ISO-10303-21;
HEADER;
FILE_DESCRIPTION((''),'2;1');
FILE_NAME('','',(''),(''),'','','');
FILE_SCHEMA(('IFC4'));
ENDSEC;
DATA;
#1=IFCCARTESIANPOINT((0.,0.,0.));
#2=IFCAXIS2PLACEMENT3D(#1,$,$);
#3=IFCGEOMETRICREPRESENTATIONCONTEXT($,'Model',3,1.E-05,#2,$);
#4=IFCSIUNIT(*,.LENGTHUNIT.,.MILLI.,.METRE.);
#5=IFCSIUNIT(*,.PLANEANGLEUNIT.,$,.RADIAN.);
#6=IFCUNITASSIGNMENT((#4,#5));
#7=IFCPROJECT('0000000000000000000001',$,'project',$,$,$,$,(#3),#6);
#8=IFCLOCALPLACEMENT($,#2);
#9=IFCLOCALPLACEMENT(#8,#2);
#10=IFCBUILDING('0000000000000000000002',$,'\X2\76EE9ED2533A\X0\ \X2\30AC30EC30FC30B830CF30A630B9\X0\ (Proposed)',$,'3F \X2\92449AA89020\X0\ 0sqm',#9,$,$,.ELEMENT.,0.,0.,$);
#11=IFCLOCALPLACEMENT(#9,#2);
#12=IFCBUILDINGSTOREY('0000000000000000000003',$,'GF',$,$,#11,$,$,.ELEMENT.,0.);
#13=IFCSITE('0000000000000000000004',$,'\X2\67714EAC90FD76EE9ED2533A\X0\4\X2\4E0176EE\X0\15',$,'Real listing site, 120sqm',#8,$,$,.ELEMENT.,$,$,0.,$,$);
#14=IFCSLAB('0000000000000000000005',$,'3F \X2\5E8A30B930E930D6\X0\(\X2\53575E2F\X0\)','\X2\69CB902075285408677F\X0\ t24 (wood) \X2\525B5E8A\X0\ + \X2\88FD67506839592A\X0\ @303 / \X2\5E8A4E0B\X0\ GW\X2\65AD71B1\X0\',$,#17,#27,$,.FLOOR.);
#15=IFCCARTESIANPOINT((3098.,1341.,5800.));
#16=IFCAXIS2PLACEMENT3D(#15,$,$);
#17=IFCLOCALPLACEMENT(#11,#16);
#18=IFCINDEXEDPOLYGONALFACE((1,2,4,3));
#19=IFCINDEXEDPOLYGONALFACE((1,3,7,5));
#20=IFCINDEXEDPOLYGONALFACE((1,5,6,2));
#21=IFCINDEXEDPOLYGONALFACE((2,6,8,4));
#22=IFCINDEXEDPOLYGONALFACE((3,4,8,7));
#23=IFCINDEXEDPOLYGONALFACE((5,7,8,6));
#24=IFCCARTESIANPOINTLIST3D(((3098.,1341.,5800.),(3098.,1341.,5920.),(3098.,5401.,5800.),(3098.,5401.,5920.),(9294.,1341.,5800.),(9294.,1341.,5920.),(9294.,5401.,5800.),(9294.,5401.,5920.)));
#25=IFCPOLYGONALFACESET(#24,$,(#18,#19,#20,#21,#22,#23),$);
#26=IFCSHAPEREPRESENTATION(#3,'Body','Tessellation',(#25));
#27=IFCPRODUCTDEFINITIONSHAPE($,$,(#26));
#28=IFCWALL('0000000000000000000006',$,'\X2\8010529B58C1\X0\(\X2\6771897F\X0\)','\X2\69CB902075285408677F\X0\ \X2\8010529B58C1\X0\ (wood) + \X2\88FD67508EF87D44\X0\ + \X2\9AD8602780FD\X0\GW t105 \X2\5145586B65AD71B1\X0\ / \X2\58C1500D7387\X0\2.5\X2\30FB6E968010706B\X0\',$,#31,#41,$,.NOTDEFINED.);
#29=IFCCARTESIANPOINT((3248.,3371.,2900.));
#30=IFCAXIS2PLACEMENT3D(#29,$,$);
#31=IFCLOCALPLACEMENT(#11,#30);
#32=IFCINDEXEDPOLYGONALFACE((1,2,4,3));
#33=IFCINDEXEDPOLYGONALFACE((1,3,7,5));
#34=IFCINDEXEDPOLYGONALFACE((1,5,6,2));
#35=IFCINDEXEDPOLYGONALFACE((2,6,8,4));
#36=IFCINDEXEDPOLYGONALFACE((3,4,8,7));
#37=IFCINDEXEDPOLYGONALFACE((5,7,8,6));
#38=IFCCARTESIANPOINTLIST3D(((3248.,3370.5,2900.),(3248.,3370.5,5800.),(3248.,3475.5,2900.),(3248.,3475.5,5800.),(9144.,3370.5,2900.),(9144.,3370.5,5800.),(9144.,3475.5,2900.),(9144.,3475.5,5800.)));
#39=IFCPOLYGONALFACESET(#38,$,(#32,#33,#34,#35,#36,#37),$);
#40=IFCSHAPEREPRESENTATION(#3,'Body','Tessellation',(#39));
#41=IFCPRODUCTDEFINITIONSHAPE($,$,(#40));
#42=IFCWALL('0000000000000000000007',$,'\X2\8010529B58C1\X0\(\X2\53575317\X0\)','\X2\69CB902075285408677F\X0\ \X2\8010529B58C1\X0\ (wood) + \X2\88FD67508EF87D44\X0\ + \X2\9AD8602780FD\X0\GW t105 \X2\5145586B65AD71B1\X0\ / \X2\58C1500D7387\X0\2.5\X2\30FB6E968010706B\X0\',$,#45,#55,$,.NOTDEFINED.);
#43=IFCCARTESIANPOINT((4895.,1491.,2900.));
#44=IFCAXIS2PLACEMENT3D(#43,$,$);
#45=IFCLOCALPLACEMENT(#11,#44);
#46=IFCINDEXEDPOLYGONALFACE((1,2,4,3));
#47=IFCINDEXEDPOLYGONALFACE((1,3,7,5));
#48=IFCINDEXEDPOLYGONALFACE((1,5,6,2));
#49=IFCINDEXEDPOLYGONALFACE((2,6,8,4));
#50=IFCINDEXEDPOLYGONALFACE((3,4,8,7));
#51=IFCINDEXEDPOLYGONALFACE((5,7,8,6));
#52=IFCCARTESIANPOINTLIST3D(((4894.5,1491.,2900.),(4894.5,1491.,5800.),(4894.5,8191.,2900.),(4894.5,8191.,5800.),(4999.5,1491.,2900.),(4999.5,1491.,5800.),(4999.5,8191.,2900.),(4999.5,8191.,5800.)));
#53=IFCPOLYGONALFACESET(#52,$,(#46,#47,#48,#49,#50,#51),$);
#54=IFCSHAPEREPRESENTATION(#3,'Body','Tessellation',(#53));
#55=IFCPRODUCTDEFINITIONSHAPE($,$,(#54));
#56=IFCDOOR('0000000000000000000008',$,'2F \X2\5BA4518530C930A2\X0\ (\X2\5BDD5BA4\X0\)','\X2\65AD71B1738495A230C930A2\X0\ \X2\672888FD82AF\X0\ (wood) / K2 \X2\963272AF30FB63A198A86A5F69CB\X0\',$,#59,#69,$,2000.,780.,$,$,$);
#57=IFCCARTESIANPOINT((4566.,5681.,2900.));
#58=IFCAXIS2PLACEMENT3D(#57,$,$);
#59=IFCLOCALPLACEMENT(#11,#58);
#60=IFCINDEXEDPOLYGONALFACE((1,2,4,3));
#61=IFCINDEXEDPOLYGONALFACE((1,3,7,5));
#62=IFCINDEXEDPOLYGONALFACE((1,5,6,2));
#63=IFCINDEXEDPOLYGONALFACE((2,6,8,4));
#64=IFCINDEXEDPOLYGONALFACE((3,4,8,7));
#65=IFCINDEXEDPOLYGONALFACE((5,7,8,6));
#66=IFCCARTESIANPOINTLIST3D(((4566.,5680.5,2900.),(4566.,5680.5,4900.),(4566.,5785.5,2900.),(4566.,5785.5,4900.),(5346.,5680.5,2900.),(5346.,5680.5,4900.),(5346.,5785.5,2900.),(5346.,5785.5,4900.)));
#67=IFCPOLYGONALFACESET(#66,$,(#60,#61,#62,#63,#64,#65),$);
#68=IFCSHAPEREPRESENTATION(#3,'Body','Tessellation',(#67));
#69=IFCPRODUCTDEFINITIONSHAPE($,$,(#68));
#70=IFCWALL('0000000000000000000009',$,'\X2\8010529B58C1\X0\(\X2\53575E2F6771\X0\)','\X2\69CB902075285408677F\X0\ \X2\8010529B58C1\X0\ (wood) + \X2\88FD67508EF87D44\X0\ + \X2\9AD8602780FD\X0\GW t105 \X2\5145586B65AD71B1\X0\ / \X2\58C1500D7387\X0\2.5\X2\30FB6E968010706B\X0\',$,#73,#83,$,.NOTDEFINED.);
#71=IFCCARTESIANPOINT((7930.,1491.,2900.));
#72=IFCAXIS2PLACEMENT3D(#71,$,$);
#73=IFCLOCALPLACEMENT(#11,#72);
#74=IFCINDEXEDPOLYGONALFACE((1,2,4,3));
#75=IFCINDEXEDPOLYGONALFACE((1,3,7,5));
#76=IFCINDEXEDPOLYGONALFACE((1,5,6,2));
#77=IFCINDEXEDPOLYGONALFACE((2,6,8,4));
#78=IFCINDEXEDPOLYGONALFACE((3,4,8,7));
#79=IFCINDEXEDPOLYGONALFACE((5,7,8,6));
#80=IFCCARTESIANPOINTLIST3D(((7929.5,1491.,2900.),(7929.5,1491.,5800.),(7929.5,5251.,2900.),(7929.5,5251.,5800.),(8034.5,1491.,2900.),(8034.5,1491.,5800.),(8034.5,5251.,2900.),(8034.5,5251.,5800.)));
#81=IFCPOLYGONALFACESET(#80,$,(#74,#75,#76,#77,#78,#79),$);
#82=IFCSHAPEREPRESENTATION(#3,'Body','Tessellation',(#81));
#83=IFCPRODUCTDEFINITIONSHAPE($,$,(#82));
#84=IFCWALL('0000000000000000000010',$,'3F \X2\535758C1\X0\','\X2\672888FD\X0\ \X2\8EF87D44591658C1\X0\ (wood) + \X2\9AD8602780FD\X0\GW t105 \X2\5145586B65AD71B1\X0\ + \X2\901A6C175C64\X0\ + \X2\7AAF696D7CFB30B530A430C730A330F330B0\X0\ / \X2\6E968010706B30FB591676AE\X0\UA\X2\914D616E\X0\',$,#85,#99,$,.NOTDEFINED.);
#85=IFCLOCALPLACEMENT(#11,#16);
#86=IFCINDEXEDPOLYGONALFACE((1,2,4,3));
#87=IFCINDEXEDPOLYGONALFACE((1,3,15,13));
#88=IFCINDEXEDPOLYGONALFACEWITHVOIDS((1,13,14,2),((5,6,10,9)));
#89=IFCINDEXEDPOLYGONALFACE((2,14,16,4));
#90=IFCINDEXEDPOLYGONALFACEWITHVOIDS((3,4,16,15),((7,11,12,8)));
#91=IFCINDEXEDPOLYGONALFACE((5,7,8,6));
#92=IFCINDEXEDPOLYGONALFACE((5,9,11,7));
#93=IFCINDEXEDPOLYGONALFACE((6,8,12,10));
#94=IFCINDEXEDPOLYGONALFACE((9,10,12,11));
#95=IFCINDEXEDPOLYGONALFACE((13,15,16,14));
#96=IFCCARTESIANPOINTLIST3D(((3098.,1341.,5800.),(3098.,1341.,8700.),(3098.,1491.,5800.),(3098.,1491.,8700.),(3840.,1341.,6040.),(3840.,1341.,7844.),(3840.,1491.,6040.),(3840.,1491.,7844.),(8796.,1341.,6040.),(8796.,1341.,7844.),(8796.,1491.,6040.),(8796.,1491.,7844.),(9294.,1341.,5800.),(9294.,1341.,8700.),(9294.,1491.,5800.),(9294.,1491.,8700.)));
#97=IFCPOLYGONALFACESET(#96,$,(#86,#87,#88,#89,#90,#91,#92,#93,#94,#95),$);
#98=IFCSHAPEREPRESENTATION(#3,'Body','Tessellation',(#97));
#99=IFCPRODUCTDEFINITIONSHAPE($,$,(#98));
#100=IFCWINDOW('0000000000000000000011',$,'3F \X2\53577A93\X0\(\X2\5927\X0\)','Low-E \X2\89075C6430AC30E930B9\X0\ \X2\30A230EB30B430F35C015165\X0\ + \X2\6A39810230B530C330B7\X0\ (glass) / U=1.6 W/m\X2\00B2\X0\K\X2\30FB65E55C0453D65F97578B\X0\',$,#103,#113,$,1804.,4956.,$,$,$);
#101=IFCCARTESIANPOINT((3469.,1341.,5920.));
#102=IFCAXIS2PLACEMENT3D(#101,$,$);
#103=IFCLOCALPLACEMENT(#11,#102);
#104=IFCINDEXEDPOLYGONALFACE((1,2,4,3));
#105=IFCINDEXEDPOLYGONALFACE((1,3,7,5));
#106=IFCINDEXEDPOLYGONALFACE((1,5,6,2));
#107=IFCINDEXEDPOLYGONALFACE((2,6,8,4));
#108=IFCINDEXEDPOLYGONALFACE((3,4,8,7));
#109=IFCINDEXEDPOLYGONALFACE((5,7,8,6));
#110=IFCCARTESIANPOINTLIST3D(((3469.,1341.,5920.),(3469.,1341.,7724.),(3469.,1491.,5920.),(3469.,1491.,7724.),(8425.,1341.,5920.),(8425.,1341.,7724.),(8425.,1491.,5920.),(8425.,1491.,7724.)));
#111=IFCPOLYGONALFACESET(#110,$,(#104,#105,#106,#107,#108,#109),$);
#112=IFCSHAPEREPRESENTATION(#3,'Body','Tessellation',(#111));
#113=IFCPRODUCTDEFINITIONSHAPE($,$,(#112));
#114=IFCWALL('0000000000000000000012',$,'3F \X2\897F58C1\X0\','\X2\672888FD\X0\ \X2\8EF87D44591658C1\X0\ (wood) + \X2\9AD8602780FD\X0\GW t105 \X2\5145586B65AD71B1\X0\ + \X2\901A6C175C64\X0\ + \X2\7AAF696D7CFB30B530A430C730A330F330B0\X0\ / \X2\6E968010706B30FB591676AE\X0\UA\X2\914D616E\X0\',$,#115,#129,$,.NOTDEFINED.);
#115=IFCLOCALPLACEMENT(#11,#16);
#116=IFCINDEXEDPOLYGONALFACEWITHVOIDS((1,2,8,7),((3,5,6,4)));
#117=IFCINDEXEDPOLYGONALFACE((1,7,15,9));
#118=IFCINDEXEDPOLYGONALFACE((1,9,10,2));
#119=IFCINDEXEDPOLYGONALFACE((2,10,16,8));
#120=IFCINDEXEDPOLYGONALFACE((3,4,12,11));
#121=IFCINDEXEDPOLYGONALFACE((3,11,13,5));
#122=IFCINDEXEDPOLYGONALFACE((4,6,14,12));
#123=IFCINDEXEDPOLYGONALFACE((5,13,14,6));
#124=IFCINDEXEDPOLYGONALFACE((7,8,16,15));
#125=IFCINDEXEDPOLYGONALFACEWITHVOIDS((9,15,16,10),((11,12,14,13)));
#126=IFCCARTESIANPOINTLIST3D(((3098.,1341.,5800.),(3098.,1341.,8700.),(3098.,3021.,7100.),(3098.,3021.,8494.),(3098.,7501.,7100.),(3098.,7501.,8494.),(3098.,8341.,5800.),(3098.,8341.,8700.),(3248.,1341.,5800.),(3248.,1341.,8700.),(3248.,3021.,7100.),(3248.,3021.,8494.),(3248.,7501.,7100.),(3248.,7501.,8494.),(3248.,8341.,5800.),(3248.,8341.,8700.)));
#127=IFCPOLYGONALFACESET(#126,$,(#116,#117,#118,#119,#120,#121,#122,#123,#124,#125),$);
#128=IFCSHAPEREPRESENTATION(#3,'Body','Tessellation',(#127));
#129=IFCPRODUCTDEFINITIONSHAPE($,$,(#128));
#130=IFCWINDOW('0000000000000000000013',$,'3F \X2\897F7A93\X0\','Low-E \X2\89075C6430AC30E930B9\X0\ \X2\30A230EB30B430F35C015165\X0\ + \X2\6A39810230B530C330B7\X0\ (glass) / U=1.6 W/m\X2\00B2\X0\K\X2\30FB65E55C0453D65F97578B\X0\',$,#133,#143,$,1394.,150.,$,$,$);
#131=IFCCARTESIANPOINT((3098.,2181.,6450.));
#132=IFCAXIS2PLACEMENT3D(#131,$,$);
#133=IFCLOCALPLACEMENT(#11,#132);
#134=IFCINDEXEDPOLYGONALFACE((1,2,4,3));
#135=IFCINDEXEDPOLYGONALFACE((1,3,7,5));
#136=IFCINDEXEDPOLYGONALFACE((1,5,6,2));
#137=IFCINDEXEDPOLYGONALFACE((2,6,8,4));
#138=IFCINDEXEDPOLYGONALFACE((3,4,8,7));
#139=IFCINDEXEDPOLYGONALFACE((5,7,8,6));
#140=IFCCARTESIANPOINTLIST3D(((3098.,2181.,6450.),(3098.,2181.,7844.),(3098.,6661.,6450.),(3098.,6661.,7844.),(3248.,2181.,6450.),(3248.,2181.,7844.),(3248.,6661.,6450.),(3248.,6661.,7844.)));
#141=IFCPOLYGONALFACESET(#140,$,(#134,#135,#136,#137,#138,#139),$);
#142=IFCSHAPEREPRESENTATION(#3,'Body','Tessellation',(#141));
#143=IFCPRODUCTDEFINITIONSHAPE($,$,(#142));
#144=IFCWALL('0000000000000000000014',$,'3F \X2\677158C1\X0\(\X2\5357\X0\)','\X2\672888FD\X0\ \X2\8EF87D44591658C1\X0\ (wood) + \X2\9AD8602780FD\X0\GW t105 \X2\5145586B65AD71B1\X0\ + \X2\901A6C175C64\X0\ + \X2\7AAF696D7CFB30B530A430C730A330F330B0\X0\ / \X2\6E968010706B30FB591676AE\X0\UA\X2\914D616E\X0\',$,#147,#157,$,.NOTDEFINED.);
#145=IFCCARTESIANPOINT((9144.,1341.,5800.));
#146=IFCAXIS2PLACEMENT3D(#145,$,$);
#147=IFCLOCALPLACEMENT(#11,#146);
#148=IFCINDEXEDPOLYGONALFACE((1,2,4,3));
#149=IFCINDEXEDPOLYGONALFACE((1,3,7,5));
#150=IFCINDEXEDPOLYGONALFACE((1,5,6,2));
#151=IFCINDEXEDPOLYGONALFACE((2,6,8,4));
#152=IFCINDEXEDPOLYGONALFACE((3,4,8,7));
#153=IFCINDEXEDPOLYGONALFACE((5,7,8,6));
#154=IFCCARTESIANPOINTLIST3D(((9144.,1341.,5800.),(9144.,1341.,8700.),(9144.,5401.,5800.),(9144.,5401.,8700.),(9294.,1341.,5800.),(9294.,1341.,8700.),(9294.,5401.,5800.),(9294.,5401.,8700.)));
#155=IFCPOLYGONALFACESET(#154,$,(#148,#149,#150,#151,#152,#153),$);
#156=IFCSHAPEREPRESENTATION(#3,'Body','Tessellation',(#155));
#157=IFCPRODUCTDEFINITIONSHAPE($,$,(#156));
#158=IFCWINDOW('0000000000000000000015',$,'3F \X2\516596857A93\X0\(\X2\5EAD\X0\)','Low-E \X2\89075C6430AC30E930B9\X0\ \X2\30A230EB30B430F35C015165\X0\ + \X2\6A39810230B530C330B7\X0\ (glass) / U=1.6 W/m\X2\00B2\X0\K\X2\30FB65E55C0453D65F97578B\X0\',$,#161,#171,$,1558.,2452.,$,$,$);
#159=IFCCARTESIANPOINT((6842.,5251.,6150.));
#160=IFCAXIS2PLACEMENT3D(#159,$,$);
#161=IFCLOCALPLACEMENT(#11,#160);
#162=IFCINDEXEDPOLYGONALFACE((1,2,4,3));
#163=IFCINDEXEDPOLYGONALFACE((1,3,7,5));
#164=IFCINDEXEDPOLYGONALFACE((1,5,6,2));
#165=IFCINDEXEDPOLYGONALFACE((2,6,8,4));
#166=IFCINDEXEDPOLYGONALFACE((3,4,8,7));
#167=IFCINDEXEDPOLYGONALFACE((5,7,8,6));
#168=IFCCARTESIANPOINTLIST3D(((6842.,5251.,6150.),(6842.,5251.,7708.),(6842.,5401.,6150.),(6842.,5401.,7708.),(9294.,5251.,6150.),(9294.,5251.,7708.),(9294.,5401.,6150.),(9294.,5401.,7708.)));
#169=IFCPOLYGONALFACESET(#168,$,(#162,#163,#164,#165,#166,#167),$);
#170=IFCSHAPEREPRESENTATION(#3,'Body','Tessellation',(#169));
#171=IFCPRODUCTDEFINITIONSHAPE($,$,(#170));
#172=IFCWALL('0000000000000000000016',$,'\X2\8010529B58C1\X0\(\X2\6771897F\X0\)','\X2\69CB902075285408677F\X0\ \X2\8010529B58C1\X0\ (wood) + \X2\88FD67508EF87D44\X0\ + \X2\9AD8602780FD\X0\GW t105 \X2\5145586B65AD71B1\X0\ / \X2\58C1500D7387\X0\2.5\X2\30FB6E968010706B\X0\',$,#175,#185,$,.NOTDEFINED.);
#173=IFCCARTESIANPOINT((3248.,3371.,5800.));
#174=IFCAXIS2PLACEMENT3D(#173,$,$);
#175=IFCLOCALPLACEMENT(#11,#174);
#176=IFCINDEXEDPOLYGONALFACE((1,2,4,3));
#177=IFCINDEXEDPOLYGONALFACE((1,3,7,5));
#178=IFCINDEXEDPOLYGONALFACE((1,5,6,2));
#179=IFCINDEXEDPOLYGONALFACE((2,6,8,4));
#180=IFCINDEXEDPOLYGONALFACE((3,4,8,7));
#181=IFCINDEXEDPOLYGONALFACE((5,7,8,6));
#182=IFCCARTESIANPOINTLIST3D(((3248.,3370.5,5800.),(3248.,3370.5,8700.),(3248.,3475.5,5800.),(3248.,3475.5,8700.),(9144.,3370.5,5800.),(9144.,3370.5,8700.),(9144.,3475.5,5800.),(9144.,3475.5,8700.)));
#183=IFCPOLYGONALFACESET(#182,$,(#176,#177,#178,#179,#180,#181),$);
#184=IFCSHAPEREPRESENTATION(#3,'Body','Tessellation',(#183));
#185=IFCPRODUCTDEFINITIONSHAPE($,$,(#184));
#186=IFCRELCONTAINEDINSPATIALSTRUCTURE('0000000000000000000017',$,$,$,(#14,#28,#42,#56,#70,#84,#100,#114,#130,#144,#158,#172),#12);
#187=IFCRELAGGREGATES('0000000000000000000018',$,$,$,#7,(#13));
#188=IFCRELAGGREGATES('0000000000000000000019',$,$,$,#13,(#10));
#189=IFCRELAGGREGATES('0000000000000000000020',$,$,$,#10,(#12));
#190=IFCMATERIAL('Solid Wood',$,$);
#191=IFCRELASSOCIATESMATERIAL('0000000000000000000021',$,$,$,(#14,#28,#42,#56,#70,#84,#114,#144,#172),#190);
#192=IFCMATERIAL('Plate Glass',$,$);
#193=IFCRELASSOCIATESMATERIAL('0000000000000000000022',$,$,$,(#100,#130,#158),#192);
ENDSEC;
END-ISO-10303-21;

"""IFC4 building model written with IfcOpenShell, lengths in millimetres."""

from ifc_helpers import new_model, si_unit, frame, frame_2d, origin, place, context, project, spatial, rectangle, extrude, material, element, fill, save


model = new_model("IFC4")

# Units and contexts
model_context = context("Model", 3, precision=1e-05, world=origin())
ifc_project = project(units=[si_unit("LENGTHUNIT", "METRE", prefix="MILLI"), si_unit("PLANEANGLEUNIT", "RADIAN")], contexts=[model_context])

# Site, building, storey
site_placement = place(None, origin())
site = spatial("IfcSite", under=ifc_project, at=site_placement, Name="東京都目黒区4丁目15", ObjectType="Real listing site, 120sqm", CompositionType="ELEMENT", RefElevation=0.0)
building_placement = place(site_placement, origin())
building = spatial("IfcBuilding", under=site, at=building_placement, Name="目黒区 ガレージハウス (Proposed)", ObjectType="3F 鉄骨造 0sqm", CompositionType="ELEMENT", ElevationOfRefHeight=0.0, ElevationOfTerrain=0.0)
storey_placement = place(building_placement, origin())
storey = spatial("IfcBuildingStorey", under=building, at=storey_placement, Name="GF", CompositionType="ELEMENT", Elevation=0.0)

# Slab
ifc_material_1 = material(Name="Solid Wood")
slab_placement = place(storey_placement, frame((3098.0, 1341.0, 5800.0)))
element("IfcSlab", 1, at=slab_placement, inside=storey, material=ifc_material_1, Name="3F 床スラブ(南帯)", Description="構造用合板 t24 (wood) 剛床 + 製材根太 @303 / 床下 GW断熱", PredefinedType="FLOOR", context=model_context, shape_type="SweptSolid", body=[
    extrude(rectangle(XDim=6196.0, YDim=4060.0, at=frame_2d((3098.0, 2030.0))), frame((3098.0, 1341.0, 5800.0)), (0.0, 0.0, 1.0), 120.0),
])

# Wall
wall_1_placement = place(storey_placement, frame((3248.0, 3371.0, 2900.0)))
element("IfcWall", 2, at=wall_1_placement, inside=storey, material=ifc_material_1, Name="耐力壁(東西)", Description="構造用合板 耐力壁 (wood) + 製材軸組 + 高性能GW t105 充填断熱 / 壁倍率2.5・準耐火", PredefinedType="NOTDEFINED", context=model_context, shape_type="SweptSolid", body=[
    extrude(rectangle(XDim=5896.0, YDim=105.0, at=frame_2d((2948.0, 52.0))), frame((3248.0, 3371.0, 2900.0)), (0.0, 0.0, 1.0), 2900.0),
])

# Wall, opening, door
wall_2_placement = place(storey_placement, frame((4895.0, 1491.0, 2900.0)))
wall_2 = element("IfcWall", 3, at=wall_2_placement, inside=storey, material=ifc_material_1, Name="耐力壁(南北)", Description="構造用合板 耐力壁 (wood) + 製材軸組 + 高性能GW t105 充填断熱 / 壁倍率2.5・準耐火", PredefinedType="NOTDEFINED", context=model_context, shape_type="SweptSolid", body=[
    extrude(rectangle(XDim=105.0, YDim=6700.0, at=frame_2d((52.0, 3350.0))), frame((4895.0, 1491.0, 2900.0)), (0.0, 0.0, 1.0), 2900.0),
])
opening_1_placement = place(storey_placement, frame((4566.0, 5681.0, 2900.0)))
opening_1 = element("IfcOpeningElement", 4, at=opening_1_placement, cuts=wall_2, PredefinedType="NOTDEFINED", context=model_context, shape_type="SweptSolid", body=[
    extrude(rectangle(XDim=780.0, YDim=105.0, at=frame_2d((390.0, 52.0))), frame((4566.0, 5681.0, 2900.0)), (0.0, 0.0, 1.0), 2000.0),
])
door_1_placement = place(storey_placement, frame((4566.0, 5681.0, 2900.0)))
door_1 = element("IfcDoor", 5, at=door_1_placement, inside=storey, material=ifc_material_1, Name="2F 室内ドア (寝室)", Description="断熱玄関ドア 木製芯 (wood) / K2 防犯・採風機構", OverallHeight=2000.0, OverallWidth=780.0, context=model_context, shape_type="SweptSolid", body=[
    extrude(rectangle(XDim=780.0, YDim=105.0, at=frame_2d((390.0, 52.0))), frame((4566.0, 5681.0, 2900.0)), (0.0, 0.0, 1.0), 2000.0),
])
fill(opening_1, door_1)

# Wall
wall_3_placement = place(storey_placement, frame((7930.0, 1491.0, 2900.0)))
element("IfcWall", 6, at=wall_3_placement, inside=storey, material=ifc_material_1, Name="耐力壁(南帯東)", Description="構造用合板 耐力壁 (wood) + 製材軸組 + 高性能GW t105 充填断熱 / 壁倍率2.5・準耐火", PredefinedType="NOTDEFINED", context=model_context, shape_type="SweptSolid", body=[
    extrude(rectangle(XDim=105.0, YDim=3760.0, at=frame_2d((52.0, 1880.0))), frame((7930.0, 1491.0, 2900.0)), (0.0, 0.0, 1.0), 2900.0),
])

# Walls, openings, windows
wall_4_placement = place(storey_placement, frame((3098.0, 1341.0, 5800.0)))
wall_4 = element("IfcWall", 7, at=wall_4_placement, inside=storey, material=ifc_material_1, Name="3F 南壁", Description="木製 軸組外壁 (wood) + 高性能GW t105 充填断熱 + 通気層 + 窯業系サイディング / 準耐火・外皮UA配慮", PredefinedType="NOTDEFINED", context=model_context, shape_type="SweptSolid", body=[
    extrude(rectangle(XDim=6196.0, YDim=150.0, at=frame_2d((3098.0, 75.0))), frame((3098.0, 1341.0, 5800.0)), (0.0, 0.0, 1.0), 2900.0),
])
opening_2_placement = place(storey_placement, frame((3469.0, 1341.0, 5920.0)))
opening_2 = element("IfcOpeningElement", 8, at=opening_2_placement, cuts=wall_4, PredefinedType="NOTDEFINED", context=model_context, shape_type="SweptSolid", body=[
    extrude(rectangle(XDim=4956.0, YDim=150.0, at=frame_2d((2478.0, 75.0))), frame((3469.0, 1341.0, 5920.0)), (0.0, 0.0, 1.0), 1804.0),
])
ifc_material_2 = material(Name="Plate Glass")
window_1_placement = place(storey_placement, frame((3469.0, 1341.0, 5920.0)))
window_1 = element("IfcWindow", 9, at=window_1_placement, inside=storey, material=ifc_material_2, Name="3F 南窓(大)", Description="Low-E 複層ガラス アルゴン封入 + 樹脂サッシ (glass) / U=1.6 W/m²K・日射取得型", OverallHeight=1804.0, OverallWidth=4956.0, context=model_context, shape_type="SweptSolid", body=[
    extrude(rectangle(XDim=4956.0, YDim=150.0, at=frame_2d((2478.0, 75.0))), frame((3469.0, 1341.0, 5920.0)), (0.0, 0.0, 1.0), 1804.0),
])
fill(opening_2, window_1)
wall_5_placement = place(storey_placement, frame((3098.0, 1341.0, 5800.0)))
wall_5 = element("IfcWall", 10, at=wall_5_placement, inside=storey, material=ifc_material_1, Name="3F 西壁", Description="木製 軸組外壁 (wood) + 高性能GW t105 充填断熱 + 通気層 + 窯業系サイディング / 準耐火・外皮UA配慮", PredefinedType="NOTDEFINED", context=model_context, shape_type="SweptSolid", body=[
    extrude(rectangle(XDim=150.0, YDim=7000.0, at=frame_2d((75.0, 3500.0))), frame((3098.0, 1341.0, 5800.0)), (0.0, 0.0, 1.0), 2900.0),
])
opening_3_placement = place(storey_placement, frame((3098.0, 2181.0, 6450.0)))
opening_3 = element("IfcOpeningElement", 11, at=opening_3_placement, cuts=wall_5, PredefinedType="NOTDEFINED", context=model_context, shape_type="SweptSolid", body=[
    extrude(rectangle(XDim=150.0, YDim=4480.0, at=frame_2d((75.0, 2240.0))), frame((3098.0, 2181.0, 6450.0)), (0.0, 0.0, 1.0), 1394.0),
])
window_2_placement = place(storey_placement, frame((3098.0, 2181.0, 6450.0)))
window_2 = element("IfcWindow", 12, at=window_2_placement, inside=storey, material=ifc_material_2, Name="3F 西窓", Description="Low-E 複層ガラス アルゴン封入 + 樹脂サッシ (glass) / U=1.6 W/m²K・日射取得型", OverallHeight=1394.0, OverallWidth=150.0, context=model_context, shape_type="SweptSolid", body=[
    extrude(rectangle(XDim=150.0, YDim=4480.0, at=frame_2d((75.0, 2240.0))), frame((3098.0, 2181.0, 6450.0)), (0.0, 0.0, 1.0), 1394.0),
])
fill(opening_3, window_2)
wall_6_placement = place(storey_placement, frame((9144.0, 1341.0, 5800.0)))
wall_6 = element("IfcWall", 13, at=wall_6_placement, inside=storey, material=ifc_material_1, Name="3F 東壁(南)", Description="木製 軸組外壁 (wood) + 高性能GW t105 充填断熱 + 通気層 + 窯業系サイディング / 準耐火・外皮UA配慮", PredefinedType="NOTDEFINED", context=model_context, shape_type="SweptSolid", body=[
    extrude(rectangle(XDim=150.0, YDim=4060.0, at=frame_2d((75.0, 2030.0))), frame((9144.0, 1341.0, 5800.0)), (0.0, 0.0, 1.0), 2900.0),
])
opening_4_placement = place(storey_placement, frame((6842.0, 5251.0, 6150.0)))
opening_4 = element("IfcOpeningElement", 14, at=opening_4_placement, cuts=wall_6, PredefinedType="NOTDEFINED", context=model_context, shape_type="SweptSolid", body=[
    extrude(rectangle(XDim=2452.0, YDim=150.0, at=frame_2d((1226.0, 75.0))), frame((6842.0, 5251.0, 6150.0)), (0.0, 0.0, 1.0), 1558.0),
])
window_3_placement = place(storey_placement, frame((6842.0, 5251.0, 6150.0)))
window_3 = element("IfcWindow", 15, at=window_3_placement, inside=storey, material=ifc_material_2, Name="3F 入隅窓(庭)", Description="Low-E 複層ガラス アルゴン封入 + 樹脂サッシ (glass) / U=1.6 W/m²K・日射取得型", OverallHeight=1558.0, OverallWidth=2452.0, context=model_context, shape_type="SweptSolid", body=[
    extrude(rectangle(XDim=2452.0, YDim=150.0, at=frame_2d((1226.0, 75.0))), frame((6842.0, 5251.0, 6150.0)), (0.0, 0.0, 1.0), 1558.0),
])
fill(opening_4, window_3)

# Wall
wall_7_placement = place(storey_placement, frame((3248.0, 3371.0, 5800.0)))
element("IfcWall", 16, at=wall_7_placement, inside=storey, material=ifc_material_1, Name="耐力壁(東西)", Description="構造用合板 耐力壁 (wood) + 製材軸組 + 高性能GW t105 充填断熱 / 壁倍率2.5・準耐火", PredefinedType="NOTDEFINED", context=model_context, shape_type="SweptSolid", body=[
    extrude(rectangle(XDim=5896.0, YDim=105.0, at=frame_2d((2948.0, 52.0))), frame((3248.0, 3371.0, 5800.0)), (0.0, 0.0, 1.0), 2900.0),
])

save(model, "model.ifc")
